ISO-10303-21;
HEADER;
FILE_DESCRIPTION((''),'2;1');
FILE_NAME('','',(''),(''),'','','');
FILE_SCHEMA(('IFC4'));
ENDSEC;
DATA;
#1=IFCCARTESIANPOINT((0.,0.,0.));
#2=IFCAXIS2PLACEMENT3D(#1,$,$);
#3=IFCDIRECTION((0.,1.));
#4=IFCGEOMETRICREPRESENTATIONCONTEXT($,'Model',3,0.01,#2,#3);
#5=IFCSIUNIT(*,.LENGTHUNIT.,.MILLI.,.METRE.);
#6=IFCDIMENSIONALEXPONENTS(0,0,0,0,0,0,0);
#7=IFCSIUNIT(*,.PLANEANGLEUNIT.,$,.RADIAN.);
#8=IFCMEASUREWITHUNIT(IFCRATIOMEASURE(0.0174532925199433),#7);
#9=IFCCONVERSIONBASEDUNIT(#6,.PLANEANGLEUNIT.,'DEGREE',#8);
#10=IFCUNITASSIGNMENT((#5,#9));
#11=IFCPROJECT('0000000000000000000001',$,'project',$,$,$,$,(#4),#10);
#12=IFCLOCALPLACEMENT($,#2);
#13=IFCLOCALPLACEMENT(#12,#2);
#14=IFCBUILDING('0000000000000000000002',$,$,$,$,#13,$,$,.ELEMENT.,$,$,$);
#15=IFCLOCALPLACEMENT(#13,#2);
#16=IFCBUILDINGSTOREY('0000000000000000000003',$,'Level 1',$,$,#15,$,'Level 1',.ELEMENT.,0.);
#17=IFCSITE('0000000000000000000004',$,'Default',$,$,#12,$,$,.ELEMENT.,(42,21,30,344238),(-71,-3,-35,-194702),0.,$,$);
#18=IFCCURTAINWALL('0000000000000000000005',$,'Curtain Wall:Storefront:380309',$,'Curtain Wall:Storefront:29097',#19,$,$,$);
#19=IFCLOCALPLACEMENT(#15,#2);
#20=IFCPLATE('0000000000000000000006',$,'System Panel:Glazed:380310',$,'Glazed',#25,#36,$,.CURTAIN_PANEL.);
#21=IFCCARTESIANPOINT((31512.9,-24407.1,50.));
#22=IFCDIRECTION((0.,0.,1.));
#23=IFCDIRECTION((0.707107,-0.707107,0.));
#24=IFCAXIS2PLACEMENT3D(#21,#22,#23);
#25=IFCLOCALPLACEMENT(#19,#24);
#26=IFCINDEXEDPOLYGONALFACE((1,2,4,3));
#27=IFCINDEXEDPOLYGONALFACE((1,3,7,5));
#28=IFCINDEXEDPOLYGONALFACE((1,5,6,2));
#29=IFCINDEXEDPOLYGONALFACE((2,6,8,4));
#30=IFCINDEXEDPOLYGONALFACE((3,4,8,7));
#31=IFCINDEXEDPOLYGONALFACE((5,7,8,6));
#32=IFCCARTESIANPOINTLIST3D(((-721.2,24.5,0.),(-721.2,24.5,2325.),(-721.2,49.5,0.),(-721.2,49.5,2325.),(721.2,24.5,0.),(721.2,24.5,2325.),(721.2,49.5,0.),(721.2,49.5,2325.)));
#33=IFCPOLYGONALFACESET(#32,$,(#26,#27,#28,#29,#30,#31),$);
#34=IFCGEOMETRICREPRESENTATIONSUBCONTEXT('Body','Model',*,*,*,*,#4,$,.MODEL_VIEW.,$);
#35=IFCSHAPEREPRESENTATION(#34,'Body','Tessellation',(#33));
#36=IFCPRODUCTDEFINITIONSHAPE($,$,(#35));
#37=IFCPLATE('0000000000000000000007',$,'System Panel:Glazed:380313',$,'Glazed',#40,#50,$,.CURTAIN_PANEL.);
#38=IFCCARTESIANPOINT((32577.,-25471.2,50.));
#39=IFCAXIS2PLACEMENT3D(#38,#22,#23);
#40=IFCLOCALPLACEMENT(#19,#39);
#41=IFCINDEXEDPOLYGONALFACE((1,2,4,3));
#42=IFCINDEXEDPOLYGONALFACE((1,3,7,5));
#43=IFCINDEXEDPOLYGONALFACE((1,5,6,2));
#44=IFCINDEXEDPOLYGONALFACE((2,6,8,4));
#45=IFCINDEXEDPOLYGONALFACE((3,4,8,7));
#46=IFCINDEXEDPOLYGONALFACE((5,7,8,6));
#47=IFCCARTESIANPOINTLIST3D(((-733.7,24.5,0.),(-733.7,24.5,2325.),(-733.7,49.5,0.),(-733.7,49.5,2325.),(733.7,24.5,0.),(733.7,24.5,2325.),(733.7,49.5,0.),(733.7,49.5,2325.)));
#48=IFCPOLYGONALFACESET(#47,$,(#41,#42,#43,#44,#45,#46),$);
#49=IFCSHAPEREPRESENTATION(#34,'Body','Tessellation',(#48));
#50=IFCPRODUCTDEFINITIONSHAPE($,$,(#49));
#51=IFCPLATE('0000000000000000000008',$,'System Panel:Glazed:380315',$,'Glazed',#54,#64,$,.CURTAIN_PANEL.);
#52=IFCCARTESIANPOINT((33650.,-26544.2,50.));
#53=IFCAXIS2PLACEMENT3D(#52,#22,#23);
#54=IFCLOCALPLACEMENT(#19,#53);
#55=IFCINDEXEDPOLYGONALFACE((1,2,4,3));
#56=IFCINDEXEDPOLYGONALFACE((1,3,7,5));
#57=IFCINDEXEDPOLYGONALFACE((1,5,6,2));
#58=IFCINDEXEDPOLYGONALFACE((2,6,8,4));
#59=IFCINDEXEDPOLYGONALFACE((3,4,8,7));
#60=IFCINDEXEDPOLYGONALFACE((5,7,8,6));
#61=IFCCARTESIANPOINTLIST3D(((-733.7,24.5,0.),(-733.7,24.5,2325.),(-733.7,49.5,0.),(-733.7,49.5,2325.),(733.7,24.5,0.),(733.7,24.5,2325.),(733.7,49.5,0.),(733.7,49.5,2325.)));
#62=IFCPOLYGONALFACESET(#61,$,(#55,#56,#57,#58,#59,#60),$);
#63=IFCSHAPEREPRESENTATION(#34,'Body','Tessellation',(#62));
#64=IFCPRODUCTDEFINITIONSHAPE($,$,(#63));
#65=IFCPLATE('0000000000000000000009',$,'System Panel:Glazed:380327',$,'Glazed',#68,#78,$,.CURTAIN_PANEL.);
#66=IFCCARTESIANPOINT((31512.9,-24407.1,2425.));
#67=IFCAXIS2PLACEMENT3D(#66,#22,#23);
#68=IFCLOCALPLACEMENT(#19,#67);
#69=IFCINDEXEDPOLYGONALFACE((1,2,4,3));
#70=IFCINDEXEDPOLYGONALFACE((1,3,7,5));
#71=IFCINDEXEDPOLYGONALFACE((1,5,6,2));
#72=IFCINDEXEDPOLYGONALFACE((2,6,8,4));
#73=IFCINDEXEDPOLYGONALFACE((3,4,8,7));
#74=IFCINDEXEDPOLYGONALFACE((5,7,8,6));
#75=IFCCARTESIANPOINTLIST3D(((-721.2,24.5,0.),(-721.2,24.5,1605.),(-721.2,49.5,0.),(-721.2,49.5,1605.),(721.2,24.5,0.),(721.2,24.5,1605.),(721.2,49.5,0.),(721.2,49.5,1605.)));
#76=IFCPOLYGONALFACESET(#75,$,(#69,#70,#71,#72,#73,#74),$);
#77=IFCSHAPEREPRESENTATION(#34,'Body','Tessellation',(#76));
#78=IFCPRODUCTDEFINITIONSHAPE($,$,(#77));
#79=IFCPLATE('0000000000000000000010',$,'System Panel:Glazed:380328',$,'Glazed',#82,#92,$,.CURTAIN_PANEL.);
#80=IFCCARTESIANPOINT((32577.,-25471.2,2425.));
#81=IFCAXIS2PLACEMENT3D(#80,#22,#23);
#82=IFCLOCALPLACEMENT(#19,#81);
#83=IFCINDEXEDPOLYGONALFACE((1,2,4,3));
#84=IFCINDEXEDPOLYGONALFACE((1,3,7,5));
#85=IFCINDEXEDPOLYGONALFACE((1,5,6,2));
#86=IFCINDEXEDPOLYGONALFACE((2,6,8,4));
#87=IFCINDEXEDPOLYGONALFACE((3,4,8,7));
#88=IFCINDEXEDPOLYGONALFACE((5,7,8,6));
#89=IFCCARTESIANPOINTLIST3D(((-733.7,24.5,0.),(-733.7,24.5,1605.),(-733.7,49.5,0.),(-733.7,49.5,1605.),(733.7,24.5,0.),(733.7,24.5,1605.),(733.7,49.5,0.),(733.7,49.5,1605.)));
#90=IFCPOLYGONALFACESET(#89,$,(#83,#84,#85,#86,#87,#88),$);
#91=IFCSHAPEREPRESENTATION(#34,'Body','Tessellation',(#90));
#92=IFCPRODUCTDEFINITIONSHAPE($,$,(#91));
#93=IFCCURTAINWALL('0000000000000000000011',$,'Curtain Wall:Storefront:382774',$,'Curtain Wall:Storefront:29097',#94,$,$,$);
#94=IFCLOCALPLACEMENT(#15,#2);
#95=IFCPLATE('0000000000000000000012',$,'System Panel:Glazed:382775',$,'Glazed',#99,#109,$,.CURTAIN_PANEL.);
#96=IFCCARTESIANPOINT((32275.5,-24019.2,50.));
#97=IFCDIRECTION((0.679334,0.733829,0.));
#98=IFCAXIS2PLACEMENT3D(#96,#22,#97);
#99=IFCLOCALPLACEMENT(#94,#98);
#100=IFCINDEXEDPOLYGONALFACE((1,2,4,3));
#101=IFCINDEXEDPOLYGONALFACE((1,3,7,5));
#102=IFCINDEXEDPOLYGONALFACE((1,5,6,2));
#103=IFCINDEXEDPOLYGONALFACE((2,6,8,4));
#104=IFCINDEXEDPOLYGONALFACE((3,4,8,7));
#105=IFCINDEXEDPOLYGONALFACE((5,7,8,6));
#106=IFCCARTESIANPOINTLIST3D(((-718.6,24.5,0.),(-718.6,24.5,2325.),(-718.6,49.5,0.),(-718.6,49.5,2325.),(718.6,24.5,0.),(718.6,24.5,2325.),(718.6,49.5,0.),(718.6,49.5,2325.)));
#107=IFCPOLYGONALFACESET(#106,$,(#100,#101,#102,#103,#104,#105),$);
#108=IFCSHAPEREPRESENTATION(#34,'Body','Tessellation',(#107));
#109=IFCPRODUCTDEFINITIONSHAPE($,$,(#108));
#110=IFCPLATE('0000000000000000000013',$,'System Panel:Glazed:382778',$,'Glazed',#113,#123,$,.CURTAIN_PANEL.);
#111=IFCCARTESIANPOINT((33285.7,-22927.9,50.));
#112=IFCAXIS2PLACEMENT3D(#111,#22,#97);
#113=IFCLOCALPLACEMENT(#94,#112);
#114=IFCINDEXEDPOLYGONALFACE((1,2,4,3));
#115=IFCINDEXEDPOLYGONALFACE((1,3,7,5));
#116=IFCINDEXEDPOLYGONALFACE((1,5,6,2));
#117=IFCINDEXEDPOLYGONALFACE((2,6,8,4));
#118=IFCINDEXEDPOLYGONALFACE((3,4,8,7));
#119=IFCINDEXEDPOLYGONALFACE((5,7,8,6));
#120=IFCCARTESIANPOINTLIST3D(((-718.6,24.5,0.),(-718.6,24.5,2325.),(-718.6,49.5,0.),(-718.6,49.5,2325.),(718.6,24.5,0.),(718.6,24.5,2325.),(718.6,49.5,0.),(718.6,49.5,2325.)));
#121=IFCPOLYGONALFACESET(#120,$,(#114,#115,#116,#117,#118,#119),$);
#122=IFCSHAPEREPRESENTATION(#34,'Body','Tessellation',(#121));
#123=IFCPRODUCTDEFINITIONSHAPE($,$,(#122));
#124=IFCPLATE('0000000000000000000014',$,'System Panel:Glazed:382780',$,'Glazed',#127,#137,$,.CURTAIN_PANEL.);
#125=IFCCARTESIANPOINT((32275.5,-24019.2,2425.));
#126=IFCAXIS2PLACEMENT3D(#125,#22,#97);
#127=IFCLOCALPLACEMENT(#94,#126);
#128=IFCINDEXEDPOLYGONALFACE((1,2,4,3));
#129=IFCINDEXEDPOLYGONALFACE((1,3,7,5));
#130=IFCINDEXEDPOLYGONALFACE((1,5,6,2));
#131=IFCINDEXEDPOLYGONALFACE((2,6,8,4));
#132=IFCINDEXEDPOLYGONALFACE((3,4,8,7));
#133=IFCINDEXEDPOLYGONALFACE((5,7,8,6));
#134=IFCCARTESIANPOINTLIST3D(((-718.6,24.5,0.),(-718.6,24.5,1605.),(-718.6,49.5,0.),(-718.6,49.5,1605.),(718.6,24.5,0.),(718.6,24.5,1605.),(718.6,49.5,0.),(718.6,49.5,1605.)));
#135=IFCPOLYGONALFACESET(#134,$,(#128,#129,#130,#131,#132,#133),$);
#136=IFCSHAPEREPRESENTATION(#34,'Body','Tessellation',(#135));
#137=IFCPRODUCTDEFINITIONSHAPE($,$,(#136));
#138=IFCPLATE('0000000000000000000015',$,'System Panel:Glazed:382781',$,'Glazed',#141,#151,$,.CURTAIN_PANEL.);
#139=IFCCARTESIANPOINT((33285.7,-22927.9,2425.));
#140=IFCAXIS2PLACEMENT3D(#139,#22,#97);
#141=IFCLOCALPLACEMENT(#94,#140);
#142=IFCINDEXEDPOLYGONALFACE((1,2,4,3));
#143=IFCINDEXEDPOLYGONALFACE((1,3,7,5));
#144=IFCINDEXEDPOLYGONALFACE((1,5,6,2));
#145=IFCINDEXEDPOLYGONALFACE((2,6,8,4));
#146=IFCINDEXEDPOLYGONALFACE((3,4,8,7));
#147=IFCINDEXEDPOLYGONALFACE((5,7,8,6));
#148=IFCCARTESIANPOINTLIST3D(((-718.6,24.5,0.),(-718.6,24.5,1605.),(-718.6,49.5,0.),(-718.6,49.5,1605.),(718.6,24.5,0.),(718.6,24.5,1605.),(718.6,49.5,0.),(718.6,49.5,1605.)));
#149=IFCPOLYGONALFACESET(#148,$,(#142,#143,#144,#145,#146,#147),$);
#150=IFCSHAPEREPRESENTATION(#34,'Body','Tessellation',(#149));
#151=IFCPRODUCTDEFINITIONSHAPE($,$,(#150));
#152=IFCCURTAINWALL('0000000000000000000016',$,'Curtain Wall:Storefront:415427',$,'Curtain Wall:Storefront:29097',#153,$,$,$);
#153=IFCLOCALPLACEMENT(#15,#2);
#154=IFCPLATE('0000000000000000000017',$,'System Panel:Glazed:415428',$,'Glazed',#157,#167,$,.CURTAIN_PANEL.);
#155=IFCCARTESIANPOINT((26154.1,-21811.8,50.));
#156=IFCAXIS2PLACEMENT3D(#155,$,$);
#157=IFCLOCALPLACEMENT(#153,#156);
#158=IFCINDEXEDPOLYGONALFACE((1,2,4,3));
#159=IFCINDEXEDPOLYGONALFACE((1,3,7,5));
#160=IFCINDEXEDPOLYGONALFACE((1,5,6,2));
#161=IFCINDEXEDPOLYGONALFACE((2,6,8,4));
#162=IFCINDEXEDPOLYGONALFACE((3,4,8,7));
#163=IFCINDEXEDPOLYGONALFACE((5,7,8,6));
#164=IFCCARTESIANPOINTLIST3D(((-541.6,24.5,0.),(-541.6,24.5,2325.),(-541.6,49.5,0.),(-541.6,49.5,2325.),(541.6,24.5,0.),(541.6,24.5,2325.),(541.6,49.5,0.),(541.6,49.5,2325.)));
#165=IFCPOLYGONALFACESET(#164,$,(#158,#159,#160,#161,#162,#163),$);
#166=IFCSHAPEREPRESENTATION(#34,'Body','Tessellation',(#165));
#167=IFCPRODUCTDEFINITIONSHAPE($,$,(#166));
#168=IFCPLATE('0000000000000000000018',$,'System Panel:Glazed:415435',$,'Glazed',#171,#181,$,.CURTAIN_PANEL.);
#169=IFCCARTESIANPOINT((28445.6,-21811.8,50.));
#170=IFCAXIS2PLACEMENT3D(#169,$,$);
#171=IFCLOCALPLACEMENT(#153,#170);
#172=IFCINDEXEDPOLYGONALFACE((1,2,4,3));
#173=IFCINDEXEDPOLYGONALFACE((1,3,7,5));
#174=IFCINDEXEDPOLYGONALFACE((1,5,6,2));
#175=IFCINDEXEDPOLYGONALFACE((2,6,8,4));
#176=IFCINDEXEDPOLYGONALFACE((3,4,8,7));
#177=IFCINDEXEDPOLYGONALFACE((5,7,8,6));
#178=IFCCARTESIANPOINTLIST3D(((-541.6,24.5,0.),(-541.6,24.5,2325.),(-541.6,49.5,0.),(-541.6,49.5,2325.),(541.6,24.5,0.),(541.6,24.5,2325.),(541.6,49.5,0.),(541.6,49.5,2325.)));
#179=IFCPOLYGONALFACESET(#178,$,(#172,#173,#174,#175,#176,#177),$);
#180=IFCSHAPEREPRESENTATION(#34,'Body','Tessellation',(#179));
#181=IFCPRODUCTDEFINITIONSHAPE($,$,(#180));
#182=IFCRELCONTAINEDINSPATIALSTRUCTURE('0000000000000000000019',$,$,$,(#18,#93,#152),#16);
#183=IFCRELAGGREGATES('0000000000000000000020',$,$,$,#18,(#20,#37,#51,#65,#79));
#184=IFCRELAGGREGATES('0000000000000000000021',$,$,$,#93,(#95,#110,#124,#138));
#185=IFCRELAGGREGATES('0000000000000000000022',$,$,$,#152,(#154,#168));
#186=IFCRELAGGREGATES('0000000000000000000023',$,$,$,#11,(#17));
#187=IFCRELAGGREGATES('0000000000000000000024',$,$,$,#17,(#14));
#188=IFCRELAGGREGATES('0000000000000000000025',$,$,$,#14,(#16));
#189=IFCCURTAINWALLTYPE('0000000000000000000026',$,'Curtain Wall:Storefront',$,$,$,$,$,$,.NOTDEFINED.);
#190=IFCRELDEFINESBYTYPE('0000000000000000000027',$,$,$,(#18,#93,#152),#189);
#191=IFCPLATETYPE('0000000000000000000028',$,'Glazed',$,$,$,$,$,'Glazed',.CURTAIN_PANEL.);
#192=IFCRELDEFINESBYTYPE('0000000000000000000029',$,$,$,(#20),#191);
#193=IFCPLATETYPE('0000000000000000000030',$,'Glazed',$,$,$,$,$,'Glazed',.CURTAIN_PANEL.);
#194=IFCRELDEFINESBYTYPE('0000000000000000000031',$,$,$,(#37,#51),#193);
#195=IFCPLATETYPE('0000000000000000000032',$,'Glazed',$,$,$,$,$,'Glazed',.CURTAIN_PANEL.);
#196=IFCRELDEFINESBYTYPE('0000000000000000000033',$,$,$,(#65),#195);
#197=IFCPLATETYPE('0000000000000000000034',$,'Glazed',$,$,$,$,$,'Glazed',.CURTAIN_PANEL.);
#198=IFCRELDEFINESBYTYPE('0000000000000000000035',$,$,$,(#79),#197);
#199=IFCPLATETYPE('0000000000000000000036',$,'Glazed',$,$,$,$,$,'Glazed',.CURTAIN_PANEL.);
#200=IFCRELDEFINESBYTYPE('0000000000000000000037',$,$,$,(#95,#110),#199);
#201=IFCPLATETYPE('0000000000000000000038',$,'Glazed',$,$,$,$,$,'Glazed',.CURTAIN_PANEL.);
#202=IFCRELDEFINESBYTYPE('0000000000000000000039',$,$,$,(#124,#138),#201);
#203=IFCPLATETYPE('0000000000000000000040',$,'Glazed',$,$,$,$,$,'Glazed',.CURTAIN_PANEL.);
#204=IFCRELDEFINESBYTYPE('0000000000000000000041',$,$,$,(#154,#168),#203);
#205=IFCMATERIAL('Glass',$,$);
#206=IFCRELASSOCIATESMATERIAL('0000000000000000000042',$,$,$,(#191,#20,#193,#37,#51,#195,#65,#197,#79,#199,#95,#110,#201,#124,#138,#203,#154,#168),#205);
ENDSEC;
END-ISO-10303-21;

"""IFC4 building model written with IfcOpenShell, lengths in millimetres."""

from ifc_helpers import new_model, entity, si_unit, converted_unit, direction, frame, frame_2d, origin, origin_2d_with_axis, place, context, subcontext, project, spatial, rectangle, extrude, source, transform, mapped, material, type_object, type_shapes, element, aggregate, save


model = new_model("IFC4")

# Units and contexts
model_context = context("Model", 3, precision=0.01, world=origin(), true_north=direction((0.0, 1.0)))
body_context = subcontext(model_context, "Body", "Model", "MODEL_VIEW")
ifc_project = project(units=[si_unit("LENGTHUNIT", "METRE", prefix="MILLI"), converted_unit("PLANEANGLEUNIT", "DEGREE", entity("IfcRatioMeasure", 0.0174532925199433), si_unit("PLANEANGLEUNIT", "RADIAN"), dimensions=[0, 0, 0, 0, 0, 0, 0])], contexts=[model_context])

# Site, building, storey
site_placement = place(None, origin())
site = spatial("IfcSite", under=ifc_project, at=site_placement, Name="Default", CompositionType="ELEMENT", RefLatitude=(42, 21, 30, 344238), RefLongitude=(-71, -3, -35, -194702), RefElevation=0.0)
building_placement = place(site_placement, origin())
building = spatial("IfcBuilding", under=site, at=building_placement, CompositionType="ELEMENT")
storey_placement = place(building_placement, origin())
storey = spatial("IfcBuildingStorey", under=building, at=storey_placement, Name="Level 1", LongName="Level 1", CompositionType="ELEMENT", Elevation=0.0)

# Curtain walls, plates
curtain_wall_type = type_object("IfcCurtainWallType", Name="Curtain Wall:Storefront", PredefinedType="NOTDEFINED")
curtain_wall_1_placement = place(storey_placement, origin())
curtain_wall_1 = element("IfcCurtainWall", 1, at=curtain_wall_1_placement, inside=storey, type_object=curtain_wall_type, Name="Curtain Wall:Storefront:380309", ObjectType="Curtain Wall:Storefront:29097")
ifc_material_1 = material(Name="Glass")
plate_type_1 = type_object("IfcPlateType", Name="Glazed", ElementType="Glazed", PredefinedType="CURTAIN_PANEL", material=ifc_material_1)
shared_shape_1 = source(origin(), body_context, "Body", "SweptSolid", [
    extrude(rectangle(XDim=25.0, YDim=1442.4, at=frame_2d((0.0, 0.0), x_axis=(1.0, 0.0))), frame((0.0, 37.0, 0.0), z_axis=(0.0, 0.0, 1.0), x_axis=(0.0, 1.0, 0.0)), (0.0, 0.0, 1.0), 2325.0),
])
type_shapes(plate_type_1, [shared_shape_1])
plate_1_placement = place(curtain_wall_1_placement, frame((31512.9, -24407.1, 50.0), z_axis=(0.0, 0.0, 1.0), x_axis=(0.707107, -0.707107, 0.0)))
plate_1 = element("IfcPlate", 2, at=plate_1_placement, type_object=plate_type_1, material=ifc_material_1, Name="System Panel:Glazed:380310", ObjectType="Glazed", PredefinedType="CURTAIN_PANEL", context=body_context, shape_type="MappedRepresentation", body=[
    mapped(shared_shape_1, transform((0.0, 0.0, 0.0), scale=1.0)),
])
plate_type_2 = type_object("IfcPlateType", Name="Glazed", ElementType="Glazed", PredefinedType="CURTAIN_PANEL", material=ifc_material_1)
shared_shape_2 = source(origin(), body_context, "Body", "SweptSolid", [
    extrude(rectangle(XDim=25.0, YDim=1467.4, at=frame_2d((0.0, 0.0), x_axis=(1.0, 0.0))), frame((0.0, 37.0, 0.0), z_axis=(0.0, 0.0, 1.0), x_axis=(0.0, 1.0, 0.0)), (0.0, 0.0, 1.0), 2325.0),
])
type_shapes(plate_type_2, [shared_shape_2])
plate_2_placement = place(curtain_wall_1_placement, frame((32577.0, -25471.2, 50.0), z_axis=(0.0, 0.0, 1.0), x_axis=(0.707107, -0.707107, 0.0)))
plate_2 = element("IfcPlate", 3, at=plate_2_placement, type_object=plate_type_2, material=ifc_material_1, Name="System Panel:Glazed:380313", ObjectType="Glazed", PredefinedType="CURTAIN_PANEL", context=body_context, shape_type="MappedRepresentation", body=[
    mapped(shared_shape_2, transform((0.0, 0.0, 0.0), scale=1.0)),
])
plate_3_placement = place(curtain_wall_1_placement, frame((33650.0, -26544.2, 50.0), z_axis=(0.0, 0.0, 1.0), x_axis=(0.707107, -0.707107, 0.0)))
plate_3 = element("IfcPlate", 4, at=plate_3_placement, type_object=plate_type_2, material=ifc_material_1, Name="System Panel:Glazed:380315", ObjectType="Glazed", PredefinedType="CURTAIN_PANEL", context=body_context, shape_type="MappedRepresentation", body=[
    mapped(shared_shape_2, transform((0.0, 0.0, 0.0), scale=1.0)),
])
plate_type_3 = type_object("IfcPlateType", Name="Glazed", ElementType="Glazed", PredefinedType="CURTAIN_PANEL", material=ifc_material_1)
shared_shape_3 = source(origin(), body_context, "Body", "SweptSolid", [
    extrude(rectangle(XDim=25.0, YDim=1442.4, at=frame_2d((0.0, 0.0), x_axis=(1.0, 0.0))), frame((0.0, 37.0, 0.0), z_axis=(0.0, 0.0, 1.0), x_axis=(0.0, 1.0, 0.0)), (0.0, 0.0, 1.0), 1605.0),
])
type_shapes(plate_type_3, [shared_shape_3])
plate_4_placement = place(curtain_wall_1_placement, frame((31512.9, -24407.1, 2425.0), z_axis=(0.0, 0.0, 1.0), x_axis=(0.707107, -0.707107, 0.0)))
plate_4 = element("IfcPlate", 5, at=plate_4_placement, type_object=plate_type_3, material=ifc_material_1, Name="System Panel:Glazed:380327", ObjectType="Glazed", PredefinedType="CURTAIN_PANEL", context=body_context, shape_type="MappedRepresentation", body=[
    mapped(shared_shape_3, transform((0.0, 0.0, 0.0), scale=1.0)),
])
plate_type_4 = type_object("IfcPlateType", Name="Glazed", ElementType="Glazed", PredefinedType="CURTAIN_PANEL", material=ifc_material_1)
shared_shape_4 = source(origin(), body_context, "Body", "SweptSolid", [
    extrude(rectangle(XDim=25.0, YDim=1467.4, at=frame_2d((0.0, 0.0), x_axis=(1.0, 0.0))), frame((0.0, 37.0, 0.0), z_axis=(0.0, 0.0, 1.0), x_axis=(0.0, 1.0, 0.0)), (0.0, 0.0, 1.0), 1605.0),
])
type_shapes(plate_type_4, [shared_shape_4])
plate_5_placement = place(curtain_wall_1_placement, frame((32577.0, -25471.2, 2425.0), z_axis=(0.0, 0.0, 1.0), x_axis=(0.707107, -0.707107, 0.0)))
plate_5 = element("IfcPlate", 6, at=plate_5_placement, type_object=plate_type_4, material=ifc_material_1, Name="System Panel:Glazed:380328", ObjectType="Glazed", PredefinedType="CURTAIN_PANEL", context=body_context, shape_type="MappedRepresentation", body=[
    mapped(shared_shape_4, transform((0.0, 0.0, 0.0), scale=1.0)),
])
aggregate(curtain_wall_1, [plate_1, plate_2, plate_3, plate_4, plate_5])
curtain_wall_2_placement = place(storey_placement, origin())
curtain_wall_2 = element("IfcCurtainWall", 7, at=curtain_wall_2_placement, inside=storey, type_object=curtain_wall_type, Name="Curtain Wall:Storefront:382774", ObjectType="Curtain Wall:Storefront:29097")
plate_type_5 = type_object("IfcPlateType", Name="Glazed", ElementType="Glazed", PredefinedType="CURTAIN_PANEL", material=ifc_material_1)
shared_shape_5 = source(origin(), body_context, "Body", "SweptSolid", [
    extrude(rectangle(XDim=25.0, YDim=1437.1, at=origin_2d_with_axis()), frame((0.0, 37.0, 0.0), z_axis=(0.0, 0.0, 1.0), x_axis=(0.0, 1.0, 0.0)), (0.0, 0.0, 1.0), 2325.0),
])
type_shapes(plate_type_5, [shared_shape_5])
plate_6_placement = place(curtain_wall_2_placement, frame((32275.5, -24019.2, 50.0), z_axis=(0.0, 0.0, 1.0), x_axis=(0.679334, 0.733829, 0.0)))
plate_6 = element("IfcPlate", 8, at=plate_6_placement, type_object=plate_type_5, material=ifc_material_1, Name="System Panel:Glazed:382775", ObjectType="Glazed", PredefinedType="CURTAIN_PANEL", context=body_context, shape_type="MappedRepresentation", body=[
    mapped(shared_shape_5, transform((0.0, 0.0, 0.0), scale=1.0)),
])
plate_7_placement = place(curtain_wall_2_placement, frame((33285.7, -22927.9, 50.0), z_axis=(0.0, 0.0, 1.0), x_axis=(0.679334, 0.733829, 0.0)))
plate_7 = element("IfcPlate", 9, at=plate_7_placement, type_object=plate_type_5, material=ifc_material_1, Name="System Panel:Glazed:382778", ObjectType="Glazed", PredefinedType="CURTAIN_PANEL", context=body_context, shape_type="MappedRepresentation", body=[
    mapped(shared_shape_5, transform((0.0, 0.0, 0.0), scale=1.0)),
])
plate_type_6 = type_object("IfcPlateType", Name="Glazed", ElementType="Glazed", PredefinedType="CURTAIN_PANEL", material=ifc_material_1)
shared_shape_6 = source(origin(), body_context, "Body", "SweptSolid", [
    extrude(rectangle(XDim=25.0, YDim=1437.1, at=origin_2d_with_axis()), frame((0.0, 37.0, 0.0), z_axis=(0.0, 0.0, 1.0), x_axis=(0.0, 1.0, 0.0)), (0.0, 0.0, 1.0), 1605.0),
])
type_shapes(plate_type_6, [shared_shape_6])
plate_8_placement = place(curtain_wall_2_placement, frame((32275.5, -24019.2, 2425.0), z_axis=(0.0, 0.0, 1.0), x_axis=(0.679334, 0.733829, 0.0)))
plate_8 = element("IfcPlate", 10, at=plate_8_placement, type_object=plate_type_6, material=ifc_material_1, Name="System Panel:Glazed:382780", ObjectType="Glazed", PredefinedType="CURTAIN_PANEL", context=body_context, shape_type="MappedRepresentation", body=[
    mapped(shared_shape_6, transform((0.0, 0.0, 0.0), scale=1.0)),
])
plate_9_placement = place(curtain_wall_2_placement, frame((33285.7, -22927.9, 2425.0), z_axis=(0.0, 0.0, 1.0), x_axis=(0.679334, 0.733829, 0.0)))
plate_9 = element("IfcPlate", 11, at=plate_9_placement, type_object=plate_type_6, material=ifc_material_1, Name="System Panel:Glazed:382781", ObjectType="Glazed", PredefinedType="CURTAIN_PANEL", context=body_context, shape_type="MappedRepresentation", body=[
    mapped(shared_shape_6, transform((0.0, 0.0, 0.0), scale=1.0)),
])
aggregate(curtain_wall_2, [plate_6, plate_7, plate_8, plate_9])
curtain_wall_3_placement = place(storey_placement, origin())
curtain_wall_3 = element("IfcCurtainWall", 12, at=curtain_wall_3_placement, inside=storey, type_object=curtain_wall_type, Name="Curtain Wall:Storefront:415427", ObjectType="Curtain Wall:Storefront:29097")
plate_type_7 = type_object("IfcPlateType", Name="Glazed", ElementType="Glazed", PredefinedType="CURTAIN_PANEL", material=ifc_material_1)
shared_shape_7 = source(origin(), body_context, "Body", "SweptSolid", [
    extrude(rectangle(XDim=25.0, YDim=1083.3, at=origin_2d_with_axis()), frame((0.0, 37.0, 0.0), z_axis=(0.0, 0.0, 1.0), x_axis=(0.0, 1.0, 0.0)), (0.0, 0.0, 1.0), 2325.0),
])
type_shapes(plate_type_7, [shared_shape_7])
plate_10_placement = place(curtain_wall_3_placement, frame((26154.1, -21811.8, 50.0)))
plate_10 = element("IfcPlate", 13, at=plate_10_placement, type_object=plate_type_7, material=ifc_material_1, Name="System Panel:Glazed:415428", ObjectType="Glazed", PredefinedType="CURTAIN_PANEL", context=body_context, shape_type="MappedRepresentation", body=[
    mapped(shared_shape_7, transform((0.0, 0.0, 0.0), scale=1.0)),
])
plate_11_placement = place(curtain_wall_3_placement, frame((28445.6, -21811.8, 50.0)))
plate_11 = element("IfcPlate", 14, at=plate_11_placement, type_object=plate_type_7, material=ifc_material_1, Name="System Panel:Glazed:415435", ObjectType="Glazed", PredefinedType="CURTAIN_PANEL", context=body_context, shape_type="MappedRepresentation", body=[
    mapped(shared_shape_7, transform((0.0, 0.0, 0.0), scale=1.0)),
])
aggregate(curtain_wall_3, [plate_10, plate_11])

save(model, "model.ifc")
